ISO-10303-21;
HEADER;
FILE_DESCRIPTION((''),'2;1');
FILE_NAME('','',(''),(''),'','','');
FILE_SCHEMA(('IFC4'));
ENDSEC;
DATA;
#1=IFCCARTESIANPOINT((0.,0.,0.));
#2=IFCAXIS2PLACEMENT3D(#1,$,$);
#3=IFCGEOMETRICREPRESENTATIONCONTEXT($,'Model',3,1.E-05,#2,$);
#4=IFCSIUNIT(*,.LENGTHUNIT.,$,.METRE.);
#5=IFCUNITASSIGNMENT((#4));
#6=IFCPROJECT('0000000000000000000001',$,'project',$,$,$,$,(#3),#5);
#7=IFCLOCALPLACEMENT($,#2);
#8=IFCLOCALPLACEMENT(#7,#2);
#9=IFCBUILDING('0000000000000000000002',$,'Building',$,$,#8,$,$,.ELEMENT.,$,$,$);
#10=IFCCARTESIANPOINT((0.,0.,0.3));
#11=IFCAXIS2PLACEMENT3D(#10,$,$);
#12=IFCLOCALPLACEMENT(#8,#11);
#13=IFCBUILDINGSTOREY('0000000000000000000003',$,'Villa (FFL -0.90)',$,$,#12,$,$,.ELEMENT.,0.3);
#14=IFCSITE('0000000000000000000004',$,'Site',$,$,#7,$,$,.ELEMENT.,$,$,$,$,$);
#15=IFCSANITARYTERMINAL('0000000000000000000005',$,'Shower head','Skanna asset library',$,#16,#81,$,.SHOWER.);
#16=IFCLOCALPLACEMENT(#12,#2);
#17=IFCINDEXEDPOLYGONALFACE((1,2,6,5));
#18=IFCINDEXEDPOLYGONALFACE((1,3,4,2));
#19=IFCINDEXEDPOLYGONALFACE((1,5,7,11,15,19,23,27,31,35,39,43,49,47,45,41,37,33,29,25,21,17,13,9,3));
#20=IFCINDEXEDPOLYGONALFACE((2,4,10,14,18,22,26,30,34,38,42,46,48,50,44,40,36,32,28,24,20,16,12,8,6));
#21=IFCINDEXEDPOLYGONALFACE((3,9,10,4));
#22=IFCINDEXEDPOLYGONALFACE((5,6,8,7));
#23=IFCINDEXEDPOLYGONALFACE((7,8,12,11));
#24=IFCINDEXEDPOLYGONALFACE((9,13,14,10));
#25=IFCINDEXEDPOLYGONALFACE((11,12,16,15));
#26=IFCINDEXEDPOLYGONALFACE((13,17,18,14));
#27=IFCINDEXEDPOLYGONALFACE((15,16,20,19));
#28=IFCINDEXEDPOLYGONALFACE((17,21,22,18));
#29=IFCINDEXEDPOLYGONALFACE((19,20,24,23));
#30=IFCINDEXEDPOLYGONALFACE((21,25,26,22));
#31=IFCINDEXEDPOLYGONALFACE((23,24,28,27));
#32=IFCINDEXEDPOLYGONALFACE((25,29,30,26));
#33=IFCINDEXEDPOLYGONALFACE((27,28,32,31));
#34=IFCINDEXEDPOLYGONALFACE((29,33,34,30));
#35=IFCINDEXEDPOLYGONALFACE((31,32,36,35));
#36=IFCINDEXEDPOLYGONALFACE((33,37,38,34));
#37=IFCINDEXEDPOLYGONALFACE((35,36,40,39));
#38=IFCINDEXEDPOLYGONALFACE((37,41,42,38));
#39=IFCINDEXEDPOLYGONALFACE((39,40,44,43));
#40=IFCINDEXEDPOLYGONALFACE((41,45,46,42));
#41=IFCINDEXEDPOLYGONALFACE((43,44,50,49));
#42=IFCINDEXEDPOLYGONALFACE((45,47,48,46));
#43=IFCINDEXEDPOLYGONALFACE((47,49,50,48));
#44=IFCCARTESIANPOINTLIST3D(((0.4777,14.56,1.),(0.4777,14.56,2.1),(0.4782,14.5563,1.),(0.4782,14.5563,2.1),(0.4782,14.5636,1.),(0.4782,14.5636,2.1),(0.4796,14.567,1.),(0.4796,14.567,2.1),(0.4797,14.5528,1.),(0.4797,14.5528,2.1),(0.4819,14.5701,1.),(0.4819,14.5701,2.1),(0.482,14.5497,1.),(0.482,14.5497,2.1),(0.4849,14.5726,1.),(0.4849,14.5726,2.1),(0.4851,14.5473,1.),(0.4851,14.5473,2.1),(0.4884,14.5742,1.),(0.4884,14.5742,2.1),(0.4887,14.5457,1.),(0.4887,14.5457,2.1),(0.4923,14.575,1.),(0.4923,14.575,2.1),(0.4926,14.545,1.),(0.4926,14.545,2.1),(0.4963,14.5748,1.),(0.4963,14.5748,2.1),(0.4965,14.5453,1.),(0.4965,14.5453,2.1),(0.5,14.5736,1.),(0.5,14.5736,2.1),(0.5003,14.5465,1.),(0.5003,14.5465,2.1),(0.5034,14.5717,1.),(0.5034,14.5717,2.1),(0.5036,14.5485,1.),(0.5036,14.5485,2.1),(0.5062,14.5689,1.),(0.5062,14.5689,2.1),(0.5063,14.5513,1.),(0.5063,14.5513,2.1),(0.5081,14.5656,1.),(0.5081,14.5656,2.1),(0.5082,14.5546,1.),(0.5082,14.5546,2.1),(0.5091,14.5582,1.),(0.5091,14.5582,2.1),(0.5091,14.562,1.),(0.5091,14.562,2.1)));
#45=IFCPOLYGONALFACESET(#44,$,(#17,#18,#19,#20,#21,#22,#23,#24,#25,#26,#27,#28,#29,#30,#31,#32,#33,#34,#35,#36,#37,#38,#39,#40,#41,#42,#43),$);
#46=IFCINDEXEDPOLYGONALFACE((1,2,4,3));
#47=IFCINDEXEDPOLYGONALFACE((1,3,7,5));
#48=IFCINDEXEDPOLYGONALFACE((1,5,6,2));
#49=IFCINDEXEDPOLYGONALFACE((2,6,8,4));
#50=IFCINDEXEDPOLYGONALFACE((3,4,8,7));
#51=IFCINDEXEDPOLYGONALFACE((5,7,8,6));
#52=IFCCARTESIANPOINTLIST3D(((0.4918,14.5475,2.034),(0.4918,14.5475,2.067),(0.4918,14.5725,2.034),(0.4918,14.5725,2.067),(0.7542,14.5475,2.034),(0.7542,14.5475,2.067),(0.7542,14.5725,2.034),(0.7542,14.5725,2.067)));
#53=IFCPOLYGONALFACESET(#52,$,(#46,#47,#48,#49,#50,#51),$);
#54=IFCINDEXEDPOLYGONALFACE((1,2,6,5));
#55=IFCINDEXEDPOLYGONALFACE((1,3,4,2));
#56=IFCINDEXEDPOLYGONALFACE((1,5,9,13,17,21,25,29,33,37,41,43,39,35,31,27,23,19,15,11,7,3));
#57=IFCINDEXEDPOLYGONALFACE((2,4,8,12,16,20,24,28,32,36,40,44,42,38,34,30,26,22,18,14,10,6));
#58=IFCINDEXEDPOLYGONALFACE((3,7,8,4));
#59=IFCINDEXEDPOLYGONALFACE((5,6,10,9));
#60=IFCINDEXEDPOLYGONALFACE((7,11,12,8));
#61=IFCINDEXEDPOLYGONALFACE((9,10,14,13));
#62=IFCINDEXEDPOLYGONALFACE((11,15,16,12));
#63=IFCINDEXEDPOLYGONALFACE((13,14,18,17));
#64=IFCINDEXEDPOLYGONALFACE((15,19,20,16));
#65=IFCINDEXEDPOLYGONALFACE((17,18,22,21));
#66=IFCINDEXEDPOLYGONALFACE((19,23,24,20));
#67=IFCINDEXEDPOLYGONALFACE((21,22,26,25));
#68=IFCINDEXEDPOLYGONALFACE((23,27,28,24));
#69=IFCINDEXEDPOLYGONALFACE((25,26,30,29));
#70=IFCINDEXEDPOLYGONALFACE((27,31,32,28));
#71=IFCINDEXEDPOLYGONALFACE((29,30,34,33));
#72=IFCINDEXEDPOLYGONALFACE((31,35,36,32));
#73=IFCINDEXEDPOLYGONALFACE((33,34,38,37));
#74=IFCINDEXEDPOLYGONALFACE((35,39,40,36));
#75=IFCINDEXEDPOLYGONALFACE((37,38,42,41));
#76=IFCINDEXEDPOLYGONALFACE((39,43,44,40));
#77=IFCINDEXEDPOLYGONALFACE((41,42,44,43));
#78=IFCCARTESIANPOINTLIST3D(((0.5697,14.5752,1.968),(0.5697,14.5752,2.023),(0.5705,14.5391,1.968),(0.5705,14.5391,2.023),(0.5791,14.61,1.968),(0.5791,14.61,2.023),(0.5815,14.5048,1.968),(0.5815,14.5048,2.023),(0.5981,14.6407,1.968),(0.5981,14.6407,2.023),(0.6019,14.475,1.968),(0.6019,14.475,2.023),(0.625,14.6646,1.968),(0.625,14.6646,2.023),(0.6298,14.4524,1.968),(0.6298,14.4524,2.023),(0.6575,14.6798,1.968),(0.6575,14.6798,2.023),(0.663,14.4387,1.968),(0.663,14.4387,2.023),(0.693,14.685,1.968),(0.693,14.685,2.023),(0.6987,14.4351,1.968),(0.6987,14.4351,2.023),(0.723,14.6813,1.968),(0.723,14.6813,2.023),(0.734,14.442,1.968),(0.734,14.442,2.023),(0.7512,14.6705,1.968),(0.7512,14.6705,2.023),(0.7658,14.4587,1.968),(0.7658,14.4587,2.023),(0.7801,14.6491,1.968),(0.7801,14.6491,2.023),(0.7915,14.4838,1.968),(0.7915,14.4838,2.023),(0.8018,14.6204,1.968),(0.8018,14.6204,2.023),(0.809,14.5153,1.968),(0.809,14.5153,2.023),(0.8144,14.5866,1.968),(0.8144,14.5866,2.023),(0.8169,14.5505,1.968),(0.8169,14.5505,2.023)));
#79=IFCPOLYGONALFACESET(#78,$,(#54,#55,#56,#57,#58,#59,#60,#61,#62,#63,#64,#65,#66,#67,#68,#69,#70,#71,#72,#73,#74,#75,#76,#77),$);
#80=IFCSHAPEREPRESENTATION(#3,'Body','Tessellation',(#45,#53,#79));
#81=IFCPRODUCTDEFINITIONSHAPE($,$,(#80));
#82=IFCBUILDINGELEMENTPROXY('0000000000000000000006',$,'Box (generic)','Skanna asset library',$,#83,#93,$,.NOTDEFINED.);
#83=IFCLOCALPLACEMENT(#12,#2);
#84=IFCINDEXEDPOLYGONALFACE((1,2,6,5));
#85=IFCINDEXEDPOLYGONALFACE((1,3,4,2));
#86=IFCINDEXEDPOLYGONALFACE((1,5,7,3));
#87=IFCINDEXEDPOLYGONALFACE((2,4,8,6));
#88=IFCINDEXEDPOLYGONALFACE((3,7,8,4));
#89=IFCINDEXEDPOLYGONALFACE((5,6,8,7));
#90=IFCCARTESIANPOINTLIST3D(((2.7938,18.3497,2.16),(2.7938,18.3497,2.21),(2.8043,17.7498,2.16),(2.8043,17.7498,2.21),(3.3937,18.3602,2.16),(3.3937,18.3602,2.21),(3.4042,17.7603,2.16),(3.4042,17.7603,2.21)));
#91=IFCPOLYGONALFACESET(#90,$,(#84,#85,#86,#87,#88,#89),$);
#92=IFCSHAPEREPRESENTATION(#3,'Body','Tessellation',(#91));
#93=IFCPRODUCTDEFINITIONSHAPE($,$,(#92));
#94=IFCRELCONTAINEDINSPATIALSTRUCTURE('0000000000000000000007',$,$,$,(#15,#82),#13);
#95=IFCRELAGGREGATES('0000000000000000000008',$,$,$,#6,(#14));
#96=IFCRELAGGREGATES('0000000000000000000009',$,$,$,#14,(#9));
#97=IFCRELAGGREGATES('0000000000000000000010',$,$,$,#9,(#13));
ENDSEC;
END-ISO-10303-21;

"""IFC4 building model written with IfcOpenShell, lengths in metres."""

from ifc_helpers import new_model, si_unit, frame, frame_2d, origin, origin_2d, place, context, project, spatial, rectangle, ellipse, extrude, element, save


model = new_model("IFC4")

# Units and contexts
model_context = context("Model", 3, precision=1e-05, world=origin())
ifc_project = project(units=[si_unit("LENGTHUNIT", "METRE")], contexts=[model_context])

# Site, building, storey
site_placement = place(None, origin())
site = spatial("IfcSite", under=ifc_project, at=site_placement, Name="Site", CompositionType="ELEMENT")
building_placement = place(site_placement, origin())
building = spatial("IfcBuilding", under=site, at=building_placement, Name="Building", CompositionType="ELEMENT")
storey_placement = place(building_placement, frame((0.0, 0.0, 0.3)))
storey = spatial("IfcBuildingStorey", under=building, at=storey_placement, Name="Villa (FFL -0.90)", CompositionType="ELEMENT", Elevation=0.3)

# Sanitary terminal
for number, where, z_axis, x_axis, name in (
    (1, (0.6405, 14.56, 1.0), (0.0, 0.0, 1.0), (0.0, 1.0, 0.0), "Shower head"),
):
    element("IfcSanitaryTerminal", number, at=place(storey_placement, frame(where, z_axis=z_axis, x_axis=x_axis)), inside=storey, Name=name, Description="Skanna asset library", PredefinedType="SHOWER", context=model_context, shape_type="SweptSolid", body=[
        extrude(ellipse(SemiAxis1=0.015, SemiAxis2=0.0158, at=frame_2d((0.0, 0.147))), origin(), (0.0, 0.0, 1.0), 1.1),
        extrude(rectangle(XDim=0.025, YDim=0.2625, at=frame_2d((0.0, 0.0175))), frame((0.0, 0.0, 1.034)), (0.0, 0.0, 1.0), 0.033),
        extrude(ellipse(SemiAxis1=0.125, SemiAxis2=0.1242, at=frame_2d((0.0, -0.0525))), frame((0.0, 0.0, 0.968)), (0.0, 0.0, 1.0), 0.055),
    ])

# Building element proxy
proxy_placement = place(storey_placement, frame((3.099, 18.055, 2.16), z_axis=(0.0, 0.0, 1.0), x_axis=(0.999848, 0.017452, 0.0)))
element("IfcBuildingElementProxy", 2, at=proxy_placement, inside=storey, Name="Box (generic)", Description="Skanna asset library", PredefinedType="NOTDEFINED", context=model_context, shape_type="SweptSolid", body=[
    extrude(rectangle(XDim=0.6, YDim=0.6, at=origin_2d()), origin(), (0.0, 0.0, 1.0), 0.05),
])

save(model, "model.ifc")
